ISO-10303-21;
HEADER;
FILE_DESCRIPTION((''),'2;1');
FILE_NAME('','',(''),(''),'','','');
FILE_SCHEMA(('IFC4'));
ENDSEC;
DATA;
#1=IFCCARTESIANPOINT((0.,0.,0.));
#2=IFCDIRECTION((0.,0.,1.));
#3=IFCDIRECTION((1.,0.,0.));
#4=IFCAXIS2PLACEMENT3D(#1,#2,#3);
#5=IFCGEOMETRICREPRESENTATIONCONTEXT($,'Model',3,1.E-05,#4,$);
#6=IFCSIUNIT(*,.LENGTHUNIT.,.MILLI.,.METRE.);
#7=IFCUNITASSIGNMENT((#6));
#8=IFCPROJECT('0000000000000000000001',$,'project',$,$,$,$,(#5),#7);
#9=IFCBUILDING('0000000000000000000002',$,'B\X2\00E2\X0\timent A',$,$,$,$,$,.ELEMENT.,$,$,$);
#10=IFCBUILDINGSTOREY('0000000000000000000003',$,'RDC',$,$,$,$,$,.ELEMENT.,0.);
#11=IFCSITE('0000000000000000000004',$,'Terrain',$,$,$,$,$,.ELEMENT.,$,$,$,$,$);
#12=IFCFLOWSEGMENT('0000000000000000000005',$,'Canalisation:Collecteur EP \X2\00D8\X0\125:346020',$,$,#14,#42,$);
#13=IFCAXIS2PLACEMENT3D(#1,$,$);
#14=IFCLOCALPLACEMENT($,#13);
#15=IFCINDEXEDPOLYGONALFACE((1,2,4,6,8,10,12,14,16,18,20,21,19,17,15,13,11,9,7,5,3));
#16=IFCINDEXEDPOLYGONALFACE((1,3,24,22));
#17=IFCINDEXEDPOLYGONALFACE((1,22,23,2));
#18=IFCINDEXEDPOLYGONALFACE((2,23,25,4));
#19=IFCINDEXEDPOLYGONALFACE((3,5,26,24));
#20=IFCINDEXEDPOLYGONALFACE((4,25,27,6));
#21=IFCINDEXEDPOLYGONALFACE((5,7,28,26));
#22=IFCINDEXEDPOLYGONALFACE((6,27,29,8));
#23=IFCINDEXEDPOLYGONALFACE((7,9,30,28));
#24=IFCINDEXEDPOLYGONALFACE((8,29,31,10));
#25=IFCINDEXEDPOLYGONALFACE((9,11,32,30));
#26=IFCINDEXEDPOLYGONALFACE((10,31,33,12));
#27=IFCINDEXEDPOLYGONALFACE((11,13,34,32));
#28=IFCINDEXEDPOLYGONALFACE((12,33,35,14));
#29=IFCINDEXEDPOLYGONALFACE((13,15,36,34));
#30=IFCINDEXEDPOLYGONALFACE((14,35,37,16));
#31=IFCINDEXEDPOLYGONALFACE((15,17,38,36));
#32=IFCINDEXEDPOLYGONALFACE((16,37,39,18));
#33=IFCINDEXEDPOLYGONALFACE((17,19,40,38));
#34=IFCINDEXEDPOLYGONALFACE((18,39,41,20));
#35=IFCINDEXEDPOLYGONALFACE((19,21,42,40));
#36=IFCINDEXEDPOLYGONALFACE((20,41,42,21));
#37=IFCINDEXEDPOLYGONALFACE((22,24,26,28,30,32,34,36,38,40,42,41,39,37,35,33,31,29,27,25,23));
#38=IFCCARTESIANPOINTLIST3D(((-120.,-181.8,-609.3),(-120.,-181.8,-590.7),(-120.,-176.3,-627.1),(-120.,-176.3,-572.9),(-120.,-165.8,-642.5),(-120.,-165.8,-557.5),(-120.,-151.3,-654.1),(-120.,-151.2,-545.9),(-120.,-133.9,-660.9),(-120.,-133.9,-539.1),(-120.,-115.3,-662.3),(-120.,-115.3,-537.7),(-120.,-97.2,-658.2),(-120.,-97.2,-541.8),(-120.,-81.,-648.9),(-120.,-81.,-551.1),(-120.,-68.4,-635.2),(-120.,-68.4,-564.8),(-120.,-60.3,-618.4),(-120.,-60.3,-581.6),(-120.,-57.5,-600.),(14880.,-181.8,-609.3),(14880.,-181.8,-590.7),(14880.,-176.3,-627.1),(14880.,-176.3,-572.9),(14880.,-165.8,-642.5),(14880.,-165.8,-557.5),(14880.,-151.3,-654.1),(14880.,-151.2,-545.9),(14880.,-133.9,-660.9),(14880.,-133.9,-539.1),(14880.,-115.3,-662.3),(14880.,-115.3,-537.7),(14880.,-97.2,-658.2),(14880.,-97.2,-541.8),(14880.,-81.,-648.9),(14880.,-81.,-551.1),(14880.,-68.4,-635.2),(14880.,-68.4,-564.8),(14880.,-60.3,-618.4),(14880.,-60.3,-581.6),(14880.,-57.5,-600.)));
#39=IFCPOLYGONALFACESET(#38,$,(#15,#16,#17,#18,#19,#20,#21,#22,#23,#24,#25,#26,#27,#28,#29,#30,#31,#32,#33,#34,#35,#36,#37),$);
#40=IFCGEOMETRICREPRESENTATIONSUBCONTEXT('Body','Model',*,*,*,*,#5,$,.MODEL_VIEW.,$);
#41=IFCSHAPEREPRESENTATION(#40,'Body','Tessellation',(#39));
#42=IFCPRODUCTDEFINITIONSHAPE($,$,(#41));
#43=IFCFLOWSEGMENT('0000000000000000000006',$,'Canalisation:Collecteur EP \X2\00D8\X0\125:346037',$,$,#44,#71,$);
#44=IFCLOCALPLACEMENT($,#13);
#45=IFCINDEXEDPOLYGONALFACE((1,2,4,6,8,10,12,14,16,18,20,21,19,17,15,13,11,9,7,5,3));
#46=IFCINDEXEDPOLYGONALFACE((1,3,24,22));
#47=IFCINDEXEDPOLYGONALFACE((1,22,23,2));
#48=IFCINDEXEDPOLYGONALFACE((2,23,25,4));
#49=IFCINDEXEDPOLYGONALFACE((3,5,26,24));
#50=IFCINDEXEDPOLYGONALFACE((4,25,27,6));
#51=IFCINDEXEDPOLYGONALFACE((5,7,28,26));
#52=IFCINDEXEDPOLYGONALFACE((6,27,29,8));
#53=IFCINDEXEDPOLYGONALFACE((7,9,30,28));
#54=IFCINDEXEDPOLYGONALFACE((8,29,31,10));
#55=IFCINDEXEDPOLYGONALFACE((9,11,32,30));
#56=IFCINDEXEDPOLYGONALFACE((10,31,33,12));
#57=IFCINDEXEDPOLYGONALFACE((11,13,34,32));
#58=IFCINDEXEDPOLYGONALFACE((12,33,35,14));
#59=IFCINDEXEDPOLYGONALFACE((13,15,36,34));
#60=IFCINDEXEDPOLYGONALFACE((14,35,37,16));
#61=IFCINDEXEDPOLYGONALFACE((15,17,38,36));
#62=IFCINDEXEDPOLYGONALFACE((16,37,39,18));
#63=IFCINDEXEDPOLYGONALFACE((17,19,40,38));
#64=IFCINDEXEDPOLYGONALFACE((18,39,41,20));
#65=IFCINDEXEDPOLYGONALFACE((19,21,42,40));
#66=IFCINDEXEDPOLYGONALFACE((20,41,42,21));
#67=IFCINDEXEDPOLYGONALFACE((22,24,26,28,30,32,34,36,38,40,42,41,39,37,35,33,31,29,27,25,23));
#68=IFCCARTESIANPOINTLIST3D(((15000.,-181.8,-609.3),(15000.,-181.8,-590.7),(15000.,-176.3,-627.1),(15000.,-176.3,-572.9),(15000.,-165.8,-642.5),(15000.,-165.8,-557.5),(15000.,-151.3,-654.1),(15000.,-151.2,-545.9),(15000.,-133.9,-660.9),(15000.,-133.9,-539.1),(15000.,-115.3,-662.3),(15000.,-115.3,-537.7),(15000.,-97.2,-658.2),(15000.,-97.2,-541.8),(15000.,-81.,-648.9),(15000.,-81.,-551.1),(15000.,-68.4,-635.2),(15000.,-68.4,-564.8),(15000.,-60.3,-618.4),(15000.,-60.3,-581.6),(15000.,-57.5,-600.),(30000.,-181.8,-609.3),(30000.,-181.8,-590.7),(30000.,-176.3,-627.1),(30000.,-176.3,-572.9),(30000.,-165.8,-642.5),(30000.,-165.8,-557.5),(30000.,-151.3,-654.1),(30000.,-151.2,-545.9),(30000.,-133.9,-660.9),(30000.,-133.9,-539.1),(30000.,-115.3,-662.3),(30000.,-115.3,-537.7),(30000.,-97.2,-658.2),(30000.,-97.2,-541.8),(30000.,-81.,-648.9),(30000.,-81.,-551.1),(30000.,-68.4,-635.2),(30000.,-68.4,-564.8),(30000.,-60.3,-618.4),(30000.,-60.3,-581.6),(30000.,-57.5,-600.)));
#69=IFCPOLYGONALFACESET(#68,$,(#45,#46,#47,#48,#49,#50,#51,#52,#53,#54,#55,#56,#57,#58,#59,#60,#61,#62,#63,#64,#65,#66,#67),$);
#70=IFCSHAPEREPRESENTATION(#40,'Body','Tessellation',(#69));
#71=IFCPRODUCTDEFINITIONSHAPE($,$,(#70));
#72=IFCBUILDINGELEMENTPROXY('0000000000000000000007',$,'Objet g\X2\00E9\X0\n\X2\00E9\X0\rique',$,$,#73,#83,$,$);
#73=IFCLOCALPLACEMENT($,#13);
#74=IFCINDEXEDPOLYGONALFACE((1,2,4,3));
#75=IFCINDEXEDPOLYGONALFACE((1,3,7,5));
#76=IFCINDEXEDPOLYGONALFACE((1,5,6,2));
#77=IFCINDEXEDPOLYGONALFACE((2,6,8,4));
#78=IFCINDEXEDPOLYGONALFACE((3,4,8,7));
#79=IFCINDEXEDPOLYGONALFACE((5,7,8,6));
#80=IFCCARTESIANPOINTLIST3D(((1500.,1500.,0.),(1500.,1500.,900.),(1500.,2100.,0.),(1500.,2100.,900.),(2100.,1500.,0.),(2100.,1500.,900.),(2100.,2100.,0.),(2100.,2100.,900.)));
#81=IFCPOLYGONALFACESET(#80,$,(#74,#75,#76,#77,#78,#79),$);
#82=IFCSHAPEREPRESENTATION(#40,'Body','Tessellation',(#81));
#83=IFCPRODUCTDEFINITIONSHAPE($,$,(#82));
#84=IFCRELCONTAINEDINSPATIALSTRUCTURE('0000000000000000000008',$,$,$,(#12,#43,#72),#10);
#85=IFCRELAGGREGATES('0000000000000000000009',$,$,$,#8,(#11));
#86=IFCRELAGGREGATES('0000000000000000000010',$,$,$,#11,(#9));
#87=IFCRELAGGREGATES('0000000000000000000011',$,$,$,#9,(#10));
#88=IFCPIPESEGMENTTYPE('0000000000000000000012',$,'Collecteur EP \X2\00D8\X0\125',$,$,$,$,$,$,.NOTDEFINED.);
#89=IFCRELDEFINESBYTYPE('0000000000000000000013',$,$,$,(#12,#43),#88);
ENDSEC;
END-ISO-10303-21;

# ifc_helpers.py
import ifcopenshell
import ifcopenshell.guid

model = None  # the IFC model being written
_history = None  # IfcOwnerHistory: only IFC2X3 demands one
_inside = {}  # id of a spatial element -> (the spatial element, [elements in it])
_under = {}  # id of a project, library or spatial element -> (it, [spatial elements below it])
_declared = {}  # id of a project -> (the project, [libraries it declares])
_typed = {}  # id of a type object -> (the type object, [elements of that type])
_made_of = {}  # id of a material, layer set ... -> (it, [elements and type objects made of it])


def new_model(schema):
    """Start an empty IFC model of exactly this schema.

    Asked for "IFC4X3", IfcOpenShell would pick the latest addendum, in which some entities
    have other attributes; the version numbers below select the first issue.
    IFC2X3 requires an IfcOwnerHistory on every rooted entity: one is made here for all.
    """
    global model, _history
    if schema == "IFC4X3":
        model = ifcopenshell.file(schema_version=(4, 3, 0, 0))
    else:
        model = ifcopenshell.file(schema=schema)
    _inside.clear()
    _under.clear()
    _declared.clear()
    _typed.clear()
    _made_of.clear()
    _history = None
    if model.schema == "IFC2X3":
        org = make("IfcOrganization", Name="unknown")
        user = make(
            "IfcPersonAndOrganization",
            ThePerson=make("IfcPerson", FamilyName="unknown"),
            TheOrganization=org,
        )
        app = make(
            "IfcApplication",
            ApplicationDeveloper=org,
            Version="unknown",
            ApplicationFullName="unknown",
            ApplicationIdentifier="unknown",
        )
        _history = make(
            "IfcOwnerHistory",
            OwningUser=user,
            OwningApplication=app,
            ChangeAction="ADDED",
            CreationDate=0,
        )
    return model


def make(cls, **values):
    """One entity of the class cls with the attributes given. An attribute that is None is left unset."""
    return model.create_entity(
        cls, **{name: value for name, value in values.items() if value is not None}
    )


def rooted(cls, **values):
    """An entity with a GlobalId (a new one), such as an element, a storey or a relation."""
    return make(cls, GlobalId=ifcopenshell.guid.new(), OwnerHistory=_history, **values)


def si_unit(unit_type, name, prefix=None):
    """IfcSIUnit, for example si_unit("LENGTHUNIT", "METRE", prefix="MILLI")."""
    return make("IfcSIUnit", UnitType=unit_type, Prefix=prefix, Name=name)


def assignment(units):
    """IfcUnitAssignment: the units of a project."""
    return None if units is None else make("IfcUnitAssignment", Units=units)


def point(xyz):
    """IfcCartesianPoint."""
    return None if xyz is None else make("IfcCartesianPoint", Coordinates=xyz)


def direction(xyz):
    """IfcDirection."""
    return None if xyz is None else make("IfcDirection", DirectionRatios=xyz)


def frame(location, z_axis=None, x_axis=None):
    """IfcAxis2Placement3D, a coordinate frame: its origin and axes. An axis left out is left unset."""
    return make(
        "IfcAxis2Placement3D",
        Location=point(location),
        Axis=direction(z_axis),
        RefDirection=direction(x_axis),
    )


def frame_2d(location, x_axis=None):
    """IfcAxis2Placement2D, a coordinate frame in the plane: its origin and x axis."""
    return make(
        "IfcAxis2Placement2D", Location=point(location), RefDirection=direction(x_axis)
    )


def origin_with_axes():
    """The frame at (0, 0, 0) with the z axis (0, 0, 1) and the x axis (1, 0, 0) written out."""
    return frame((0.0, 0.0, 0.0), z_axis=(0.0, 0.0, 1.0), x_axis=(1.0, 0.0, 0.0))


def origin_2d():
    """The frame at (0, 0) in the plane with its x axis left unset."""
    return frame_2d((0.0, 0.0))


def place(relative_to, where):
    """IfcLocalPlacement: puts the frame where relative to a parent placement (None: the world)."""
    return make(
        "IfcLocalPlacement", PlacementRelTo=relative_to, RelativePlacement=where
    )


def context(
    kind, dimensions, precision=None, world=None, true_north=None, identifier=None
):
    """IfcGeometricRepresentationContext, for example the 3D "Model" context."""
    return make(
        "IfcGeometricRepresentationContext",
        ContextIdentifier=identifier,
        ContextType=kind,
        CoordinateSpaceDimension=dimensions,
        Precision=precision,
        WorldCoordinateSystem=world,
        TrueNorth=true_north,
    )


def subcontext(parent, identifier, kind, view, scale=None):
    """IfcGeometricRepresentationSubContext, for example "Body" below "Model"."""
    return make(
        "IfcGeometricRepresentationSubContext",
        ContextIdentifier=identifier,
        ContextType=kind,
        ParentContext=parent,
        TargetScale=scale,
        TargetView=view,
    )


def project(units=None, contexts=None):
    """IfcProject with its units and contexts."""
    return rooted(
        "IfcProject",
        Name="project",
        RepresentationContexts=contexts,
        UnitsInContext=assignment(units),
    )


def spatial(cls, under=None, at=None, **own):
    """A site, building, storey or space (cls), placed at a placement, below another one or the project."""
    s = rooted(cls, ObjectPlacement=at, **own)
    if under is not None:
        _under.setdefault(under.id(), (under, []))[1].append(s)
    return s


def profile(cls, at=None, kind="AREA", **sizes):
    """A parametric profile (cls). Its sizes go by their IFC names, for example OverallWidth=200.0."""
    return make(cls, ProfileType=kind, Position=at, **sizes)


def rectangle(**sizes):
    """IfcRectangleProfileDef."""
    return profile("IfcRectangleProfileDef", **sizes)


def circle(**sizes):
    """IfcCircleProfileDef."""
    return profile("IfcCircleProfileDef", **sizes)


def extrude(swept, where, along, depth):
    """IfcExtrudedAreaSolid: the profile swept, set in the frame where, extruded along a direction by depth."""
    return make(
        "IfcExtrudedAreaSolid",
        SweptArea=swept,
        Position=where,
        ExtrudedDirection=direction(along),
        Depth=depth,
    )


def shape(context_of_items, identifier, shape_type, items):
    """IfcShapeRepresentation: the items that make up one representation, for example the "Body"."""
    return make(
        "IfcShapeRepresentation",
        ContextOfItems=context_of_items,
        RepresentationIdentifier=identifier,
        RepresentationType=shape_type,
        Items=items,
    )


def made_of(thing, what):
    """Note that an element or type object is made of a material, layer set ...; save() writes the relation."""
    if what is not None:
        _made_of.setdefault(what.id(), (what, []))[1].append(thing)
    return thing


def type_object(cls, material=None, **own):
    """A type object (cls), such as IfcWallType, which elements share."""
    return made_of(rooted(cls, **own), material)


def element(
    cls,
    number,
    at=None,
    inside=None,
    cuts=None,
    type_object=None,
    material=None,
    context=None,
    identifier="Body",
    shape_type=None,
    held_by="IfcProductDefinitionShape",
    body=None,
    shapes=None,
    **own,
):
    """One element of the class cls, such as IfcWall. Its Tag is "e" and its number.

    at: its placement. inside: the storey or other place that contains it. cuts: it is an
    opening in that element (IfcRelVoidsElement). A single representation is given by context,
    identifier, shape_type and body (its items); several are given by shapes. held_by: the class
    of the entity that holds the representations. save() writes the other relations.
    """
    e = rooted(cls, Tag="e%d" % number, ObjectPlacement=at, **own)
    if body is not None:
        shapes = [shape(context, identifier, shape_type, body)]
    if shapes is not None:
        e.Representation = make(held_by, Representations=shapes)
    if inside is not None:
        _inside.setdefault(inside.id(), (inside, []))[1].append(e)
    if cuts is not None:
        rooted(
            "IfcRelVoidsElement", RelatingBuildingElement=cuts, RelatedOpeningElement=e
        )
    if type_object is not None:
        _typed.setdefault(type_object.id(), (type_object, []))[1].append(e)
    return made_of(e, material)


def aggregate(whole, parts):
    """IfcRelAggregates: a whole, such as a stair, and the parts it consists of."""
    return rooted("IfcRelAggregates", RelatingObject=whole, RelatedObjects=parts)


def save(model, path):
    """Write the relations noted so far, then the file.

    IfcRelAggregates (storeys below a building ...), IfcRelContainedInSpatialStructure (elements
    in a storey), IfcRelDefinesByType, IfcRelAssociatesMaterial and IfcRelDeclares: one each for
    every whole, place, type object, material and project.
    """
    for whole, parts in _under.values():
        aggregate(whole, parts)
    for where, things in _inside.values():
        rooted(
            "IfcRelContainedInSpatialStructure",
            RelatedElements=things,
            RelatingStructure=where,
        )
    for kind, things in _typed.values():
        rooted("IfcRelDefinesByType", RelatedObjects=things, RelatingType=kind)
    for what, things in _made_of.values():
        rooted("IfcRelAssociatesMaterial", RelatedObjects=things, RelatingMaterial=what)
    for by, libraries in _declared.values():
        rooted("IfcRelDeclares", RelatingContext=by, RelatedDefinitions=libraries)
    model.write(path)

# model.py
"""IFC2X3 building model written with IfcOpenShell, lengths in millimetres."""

from ifc_helpers import new_model, si_unit, frame, frame_2d, origin_with_axes, origin_2d, place, context, subcontext, project, spatial, rectangle, circle, extrude, type_object, element, save


model = new_model("IFC2X3")

# Units and contexts
model_context = context("Model", 3, precision=1e-05, world=origin_with_axes())
body_context = subcontext(model_context, "Body", "Model", "MODEL_VIEW")
ifc_project = project(units=[si_unit("LENGTHUNIT", "METRE", prefix="MILLI")], contexts=[model_context])

# Site, building, storey
site = spatial("IfcSite", under=ifc_project, Name="Terrain", CompositionType="ELEMENT")
building = spatial("IfcBuilding", under=site, Name="Bâtiment A", CompositionType="ELEMENT")
storey = spatial("IfcBuildingStorey", under=building, Name="RDC", CompositionType="ELEMENT", Elevation=0.0)

# Flow segments
pipe_segment_type_1 = type_object("IfcPipeSegmentType", Name="Collecteur EP Ø125", PredefinedType="NOTDEFINED")
flow_segment_1_placement = place(None, origin_with_axes())
element("IfcFlowSegment", 1, at=flow_segment_1_placement, inside=storey, type_object=pipe_segment_type_1, Name="Canalisation:Collecteur EP Ø125:346020", context=body_context, shape_type="SweptSolid", body=[
    extrude(circle(Radius=62.5, at=origin_2d()), frame((-120.0, -120.0, -600.0), z_axis=(1.0, 0.0, 0.0), x_axis=(0.0, 1.0, 0.0)), (0.0, 0.0, 1.0), 15000.0),
])
flow_segment_2_placement = place(None, origin_with_axes())
element("IfcFlowSegment", 2, at=flow_segment_2_placement, inside=storey, type_object=pipe_segment_type_1, Name="Canalisation:Collecteur EP Ø125:346037", context=body_context, shape_type="SweptSolid", body=[
    extrude(circle(Radius=62.5, at=origin_2d()), frame((15000.0, -120.0, -600.0), z_axis=(1.0, 0.0, 0.0), x_axis=(0.0, 1.0, 0.0)), (0.0, 0.0, 1.0), 15000.0),
])

# Building element proxy
proxy_placement = place(None, origin_with_axes())
element("IfcBuildingElementProxy", 3, at=proxy_placement, inside=storey, Name="Objet générique", context=body_context, shape_type="SweptSolid", body=[
    extrude(rectangle(XDim=600.0, YDim=600.0, at=frame_2d((1800.0, 1800.0))), origin_with_axes(), (0.0, 0.0, 1.0), 900.0),
])

save(model, "model.ifc")
